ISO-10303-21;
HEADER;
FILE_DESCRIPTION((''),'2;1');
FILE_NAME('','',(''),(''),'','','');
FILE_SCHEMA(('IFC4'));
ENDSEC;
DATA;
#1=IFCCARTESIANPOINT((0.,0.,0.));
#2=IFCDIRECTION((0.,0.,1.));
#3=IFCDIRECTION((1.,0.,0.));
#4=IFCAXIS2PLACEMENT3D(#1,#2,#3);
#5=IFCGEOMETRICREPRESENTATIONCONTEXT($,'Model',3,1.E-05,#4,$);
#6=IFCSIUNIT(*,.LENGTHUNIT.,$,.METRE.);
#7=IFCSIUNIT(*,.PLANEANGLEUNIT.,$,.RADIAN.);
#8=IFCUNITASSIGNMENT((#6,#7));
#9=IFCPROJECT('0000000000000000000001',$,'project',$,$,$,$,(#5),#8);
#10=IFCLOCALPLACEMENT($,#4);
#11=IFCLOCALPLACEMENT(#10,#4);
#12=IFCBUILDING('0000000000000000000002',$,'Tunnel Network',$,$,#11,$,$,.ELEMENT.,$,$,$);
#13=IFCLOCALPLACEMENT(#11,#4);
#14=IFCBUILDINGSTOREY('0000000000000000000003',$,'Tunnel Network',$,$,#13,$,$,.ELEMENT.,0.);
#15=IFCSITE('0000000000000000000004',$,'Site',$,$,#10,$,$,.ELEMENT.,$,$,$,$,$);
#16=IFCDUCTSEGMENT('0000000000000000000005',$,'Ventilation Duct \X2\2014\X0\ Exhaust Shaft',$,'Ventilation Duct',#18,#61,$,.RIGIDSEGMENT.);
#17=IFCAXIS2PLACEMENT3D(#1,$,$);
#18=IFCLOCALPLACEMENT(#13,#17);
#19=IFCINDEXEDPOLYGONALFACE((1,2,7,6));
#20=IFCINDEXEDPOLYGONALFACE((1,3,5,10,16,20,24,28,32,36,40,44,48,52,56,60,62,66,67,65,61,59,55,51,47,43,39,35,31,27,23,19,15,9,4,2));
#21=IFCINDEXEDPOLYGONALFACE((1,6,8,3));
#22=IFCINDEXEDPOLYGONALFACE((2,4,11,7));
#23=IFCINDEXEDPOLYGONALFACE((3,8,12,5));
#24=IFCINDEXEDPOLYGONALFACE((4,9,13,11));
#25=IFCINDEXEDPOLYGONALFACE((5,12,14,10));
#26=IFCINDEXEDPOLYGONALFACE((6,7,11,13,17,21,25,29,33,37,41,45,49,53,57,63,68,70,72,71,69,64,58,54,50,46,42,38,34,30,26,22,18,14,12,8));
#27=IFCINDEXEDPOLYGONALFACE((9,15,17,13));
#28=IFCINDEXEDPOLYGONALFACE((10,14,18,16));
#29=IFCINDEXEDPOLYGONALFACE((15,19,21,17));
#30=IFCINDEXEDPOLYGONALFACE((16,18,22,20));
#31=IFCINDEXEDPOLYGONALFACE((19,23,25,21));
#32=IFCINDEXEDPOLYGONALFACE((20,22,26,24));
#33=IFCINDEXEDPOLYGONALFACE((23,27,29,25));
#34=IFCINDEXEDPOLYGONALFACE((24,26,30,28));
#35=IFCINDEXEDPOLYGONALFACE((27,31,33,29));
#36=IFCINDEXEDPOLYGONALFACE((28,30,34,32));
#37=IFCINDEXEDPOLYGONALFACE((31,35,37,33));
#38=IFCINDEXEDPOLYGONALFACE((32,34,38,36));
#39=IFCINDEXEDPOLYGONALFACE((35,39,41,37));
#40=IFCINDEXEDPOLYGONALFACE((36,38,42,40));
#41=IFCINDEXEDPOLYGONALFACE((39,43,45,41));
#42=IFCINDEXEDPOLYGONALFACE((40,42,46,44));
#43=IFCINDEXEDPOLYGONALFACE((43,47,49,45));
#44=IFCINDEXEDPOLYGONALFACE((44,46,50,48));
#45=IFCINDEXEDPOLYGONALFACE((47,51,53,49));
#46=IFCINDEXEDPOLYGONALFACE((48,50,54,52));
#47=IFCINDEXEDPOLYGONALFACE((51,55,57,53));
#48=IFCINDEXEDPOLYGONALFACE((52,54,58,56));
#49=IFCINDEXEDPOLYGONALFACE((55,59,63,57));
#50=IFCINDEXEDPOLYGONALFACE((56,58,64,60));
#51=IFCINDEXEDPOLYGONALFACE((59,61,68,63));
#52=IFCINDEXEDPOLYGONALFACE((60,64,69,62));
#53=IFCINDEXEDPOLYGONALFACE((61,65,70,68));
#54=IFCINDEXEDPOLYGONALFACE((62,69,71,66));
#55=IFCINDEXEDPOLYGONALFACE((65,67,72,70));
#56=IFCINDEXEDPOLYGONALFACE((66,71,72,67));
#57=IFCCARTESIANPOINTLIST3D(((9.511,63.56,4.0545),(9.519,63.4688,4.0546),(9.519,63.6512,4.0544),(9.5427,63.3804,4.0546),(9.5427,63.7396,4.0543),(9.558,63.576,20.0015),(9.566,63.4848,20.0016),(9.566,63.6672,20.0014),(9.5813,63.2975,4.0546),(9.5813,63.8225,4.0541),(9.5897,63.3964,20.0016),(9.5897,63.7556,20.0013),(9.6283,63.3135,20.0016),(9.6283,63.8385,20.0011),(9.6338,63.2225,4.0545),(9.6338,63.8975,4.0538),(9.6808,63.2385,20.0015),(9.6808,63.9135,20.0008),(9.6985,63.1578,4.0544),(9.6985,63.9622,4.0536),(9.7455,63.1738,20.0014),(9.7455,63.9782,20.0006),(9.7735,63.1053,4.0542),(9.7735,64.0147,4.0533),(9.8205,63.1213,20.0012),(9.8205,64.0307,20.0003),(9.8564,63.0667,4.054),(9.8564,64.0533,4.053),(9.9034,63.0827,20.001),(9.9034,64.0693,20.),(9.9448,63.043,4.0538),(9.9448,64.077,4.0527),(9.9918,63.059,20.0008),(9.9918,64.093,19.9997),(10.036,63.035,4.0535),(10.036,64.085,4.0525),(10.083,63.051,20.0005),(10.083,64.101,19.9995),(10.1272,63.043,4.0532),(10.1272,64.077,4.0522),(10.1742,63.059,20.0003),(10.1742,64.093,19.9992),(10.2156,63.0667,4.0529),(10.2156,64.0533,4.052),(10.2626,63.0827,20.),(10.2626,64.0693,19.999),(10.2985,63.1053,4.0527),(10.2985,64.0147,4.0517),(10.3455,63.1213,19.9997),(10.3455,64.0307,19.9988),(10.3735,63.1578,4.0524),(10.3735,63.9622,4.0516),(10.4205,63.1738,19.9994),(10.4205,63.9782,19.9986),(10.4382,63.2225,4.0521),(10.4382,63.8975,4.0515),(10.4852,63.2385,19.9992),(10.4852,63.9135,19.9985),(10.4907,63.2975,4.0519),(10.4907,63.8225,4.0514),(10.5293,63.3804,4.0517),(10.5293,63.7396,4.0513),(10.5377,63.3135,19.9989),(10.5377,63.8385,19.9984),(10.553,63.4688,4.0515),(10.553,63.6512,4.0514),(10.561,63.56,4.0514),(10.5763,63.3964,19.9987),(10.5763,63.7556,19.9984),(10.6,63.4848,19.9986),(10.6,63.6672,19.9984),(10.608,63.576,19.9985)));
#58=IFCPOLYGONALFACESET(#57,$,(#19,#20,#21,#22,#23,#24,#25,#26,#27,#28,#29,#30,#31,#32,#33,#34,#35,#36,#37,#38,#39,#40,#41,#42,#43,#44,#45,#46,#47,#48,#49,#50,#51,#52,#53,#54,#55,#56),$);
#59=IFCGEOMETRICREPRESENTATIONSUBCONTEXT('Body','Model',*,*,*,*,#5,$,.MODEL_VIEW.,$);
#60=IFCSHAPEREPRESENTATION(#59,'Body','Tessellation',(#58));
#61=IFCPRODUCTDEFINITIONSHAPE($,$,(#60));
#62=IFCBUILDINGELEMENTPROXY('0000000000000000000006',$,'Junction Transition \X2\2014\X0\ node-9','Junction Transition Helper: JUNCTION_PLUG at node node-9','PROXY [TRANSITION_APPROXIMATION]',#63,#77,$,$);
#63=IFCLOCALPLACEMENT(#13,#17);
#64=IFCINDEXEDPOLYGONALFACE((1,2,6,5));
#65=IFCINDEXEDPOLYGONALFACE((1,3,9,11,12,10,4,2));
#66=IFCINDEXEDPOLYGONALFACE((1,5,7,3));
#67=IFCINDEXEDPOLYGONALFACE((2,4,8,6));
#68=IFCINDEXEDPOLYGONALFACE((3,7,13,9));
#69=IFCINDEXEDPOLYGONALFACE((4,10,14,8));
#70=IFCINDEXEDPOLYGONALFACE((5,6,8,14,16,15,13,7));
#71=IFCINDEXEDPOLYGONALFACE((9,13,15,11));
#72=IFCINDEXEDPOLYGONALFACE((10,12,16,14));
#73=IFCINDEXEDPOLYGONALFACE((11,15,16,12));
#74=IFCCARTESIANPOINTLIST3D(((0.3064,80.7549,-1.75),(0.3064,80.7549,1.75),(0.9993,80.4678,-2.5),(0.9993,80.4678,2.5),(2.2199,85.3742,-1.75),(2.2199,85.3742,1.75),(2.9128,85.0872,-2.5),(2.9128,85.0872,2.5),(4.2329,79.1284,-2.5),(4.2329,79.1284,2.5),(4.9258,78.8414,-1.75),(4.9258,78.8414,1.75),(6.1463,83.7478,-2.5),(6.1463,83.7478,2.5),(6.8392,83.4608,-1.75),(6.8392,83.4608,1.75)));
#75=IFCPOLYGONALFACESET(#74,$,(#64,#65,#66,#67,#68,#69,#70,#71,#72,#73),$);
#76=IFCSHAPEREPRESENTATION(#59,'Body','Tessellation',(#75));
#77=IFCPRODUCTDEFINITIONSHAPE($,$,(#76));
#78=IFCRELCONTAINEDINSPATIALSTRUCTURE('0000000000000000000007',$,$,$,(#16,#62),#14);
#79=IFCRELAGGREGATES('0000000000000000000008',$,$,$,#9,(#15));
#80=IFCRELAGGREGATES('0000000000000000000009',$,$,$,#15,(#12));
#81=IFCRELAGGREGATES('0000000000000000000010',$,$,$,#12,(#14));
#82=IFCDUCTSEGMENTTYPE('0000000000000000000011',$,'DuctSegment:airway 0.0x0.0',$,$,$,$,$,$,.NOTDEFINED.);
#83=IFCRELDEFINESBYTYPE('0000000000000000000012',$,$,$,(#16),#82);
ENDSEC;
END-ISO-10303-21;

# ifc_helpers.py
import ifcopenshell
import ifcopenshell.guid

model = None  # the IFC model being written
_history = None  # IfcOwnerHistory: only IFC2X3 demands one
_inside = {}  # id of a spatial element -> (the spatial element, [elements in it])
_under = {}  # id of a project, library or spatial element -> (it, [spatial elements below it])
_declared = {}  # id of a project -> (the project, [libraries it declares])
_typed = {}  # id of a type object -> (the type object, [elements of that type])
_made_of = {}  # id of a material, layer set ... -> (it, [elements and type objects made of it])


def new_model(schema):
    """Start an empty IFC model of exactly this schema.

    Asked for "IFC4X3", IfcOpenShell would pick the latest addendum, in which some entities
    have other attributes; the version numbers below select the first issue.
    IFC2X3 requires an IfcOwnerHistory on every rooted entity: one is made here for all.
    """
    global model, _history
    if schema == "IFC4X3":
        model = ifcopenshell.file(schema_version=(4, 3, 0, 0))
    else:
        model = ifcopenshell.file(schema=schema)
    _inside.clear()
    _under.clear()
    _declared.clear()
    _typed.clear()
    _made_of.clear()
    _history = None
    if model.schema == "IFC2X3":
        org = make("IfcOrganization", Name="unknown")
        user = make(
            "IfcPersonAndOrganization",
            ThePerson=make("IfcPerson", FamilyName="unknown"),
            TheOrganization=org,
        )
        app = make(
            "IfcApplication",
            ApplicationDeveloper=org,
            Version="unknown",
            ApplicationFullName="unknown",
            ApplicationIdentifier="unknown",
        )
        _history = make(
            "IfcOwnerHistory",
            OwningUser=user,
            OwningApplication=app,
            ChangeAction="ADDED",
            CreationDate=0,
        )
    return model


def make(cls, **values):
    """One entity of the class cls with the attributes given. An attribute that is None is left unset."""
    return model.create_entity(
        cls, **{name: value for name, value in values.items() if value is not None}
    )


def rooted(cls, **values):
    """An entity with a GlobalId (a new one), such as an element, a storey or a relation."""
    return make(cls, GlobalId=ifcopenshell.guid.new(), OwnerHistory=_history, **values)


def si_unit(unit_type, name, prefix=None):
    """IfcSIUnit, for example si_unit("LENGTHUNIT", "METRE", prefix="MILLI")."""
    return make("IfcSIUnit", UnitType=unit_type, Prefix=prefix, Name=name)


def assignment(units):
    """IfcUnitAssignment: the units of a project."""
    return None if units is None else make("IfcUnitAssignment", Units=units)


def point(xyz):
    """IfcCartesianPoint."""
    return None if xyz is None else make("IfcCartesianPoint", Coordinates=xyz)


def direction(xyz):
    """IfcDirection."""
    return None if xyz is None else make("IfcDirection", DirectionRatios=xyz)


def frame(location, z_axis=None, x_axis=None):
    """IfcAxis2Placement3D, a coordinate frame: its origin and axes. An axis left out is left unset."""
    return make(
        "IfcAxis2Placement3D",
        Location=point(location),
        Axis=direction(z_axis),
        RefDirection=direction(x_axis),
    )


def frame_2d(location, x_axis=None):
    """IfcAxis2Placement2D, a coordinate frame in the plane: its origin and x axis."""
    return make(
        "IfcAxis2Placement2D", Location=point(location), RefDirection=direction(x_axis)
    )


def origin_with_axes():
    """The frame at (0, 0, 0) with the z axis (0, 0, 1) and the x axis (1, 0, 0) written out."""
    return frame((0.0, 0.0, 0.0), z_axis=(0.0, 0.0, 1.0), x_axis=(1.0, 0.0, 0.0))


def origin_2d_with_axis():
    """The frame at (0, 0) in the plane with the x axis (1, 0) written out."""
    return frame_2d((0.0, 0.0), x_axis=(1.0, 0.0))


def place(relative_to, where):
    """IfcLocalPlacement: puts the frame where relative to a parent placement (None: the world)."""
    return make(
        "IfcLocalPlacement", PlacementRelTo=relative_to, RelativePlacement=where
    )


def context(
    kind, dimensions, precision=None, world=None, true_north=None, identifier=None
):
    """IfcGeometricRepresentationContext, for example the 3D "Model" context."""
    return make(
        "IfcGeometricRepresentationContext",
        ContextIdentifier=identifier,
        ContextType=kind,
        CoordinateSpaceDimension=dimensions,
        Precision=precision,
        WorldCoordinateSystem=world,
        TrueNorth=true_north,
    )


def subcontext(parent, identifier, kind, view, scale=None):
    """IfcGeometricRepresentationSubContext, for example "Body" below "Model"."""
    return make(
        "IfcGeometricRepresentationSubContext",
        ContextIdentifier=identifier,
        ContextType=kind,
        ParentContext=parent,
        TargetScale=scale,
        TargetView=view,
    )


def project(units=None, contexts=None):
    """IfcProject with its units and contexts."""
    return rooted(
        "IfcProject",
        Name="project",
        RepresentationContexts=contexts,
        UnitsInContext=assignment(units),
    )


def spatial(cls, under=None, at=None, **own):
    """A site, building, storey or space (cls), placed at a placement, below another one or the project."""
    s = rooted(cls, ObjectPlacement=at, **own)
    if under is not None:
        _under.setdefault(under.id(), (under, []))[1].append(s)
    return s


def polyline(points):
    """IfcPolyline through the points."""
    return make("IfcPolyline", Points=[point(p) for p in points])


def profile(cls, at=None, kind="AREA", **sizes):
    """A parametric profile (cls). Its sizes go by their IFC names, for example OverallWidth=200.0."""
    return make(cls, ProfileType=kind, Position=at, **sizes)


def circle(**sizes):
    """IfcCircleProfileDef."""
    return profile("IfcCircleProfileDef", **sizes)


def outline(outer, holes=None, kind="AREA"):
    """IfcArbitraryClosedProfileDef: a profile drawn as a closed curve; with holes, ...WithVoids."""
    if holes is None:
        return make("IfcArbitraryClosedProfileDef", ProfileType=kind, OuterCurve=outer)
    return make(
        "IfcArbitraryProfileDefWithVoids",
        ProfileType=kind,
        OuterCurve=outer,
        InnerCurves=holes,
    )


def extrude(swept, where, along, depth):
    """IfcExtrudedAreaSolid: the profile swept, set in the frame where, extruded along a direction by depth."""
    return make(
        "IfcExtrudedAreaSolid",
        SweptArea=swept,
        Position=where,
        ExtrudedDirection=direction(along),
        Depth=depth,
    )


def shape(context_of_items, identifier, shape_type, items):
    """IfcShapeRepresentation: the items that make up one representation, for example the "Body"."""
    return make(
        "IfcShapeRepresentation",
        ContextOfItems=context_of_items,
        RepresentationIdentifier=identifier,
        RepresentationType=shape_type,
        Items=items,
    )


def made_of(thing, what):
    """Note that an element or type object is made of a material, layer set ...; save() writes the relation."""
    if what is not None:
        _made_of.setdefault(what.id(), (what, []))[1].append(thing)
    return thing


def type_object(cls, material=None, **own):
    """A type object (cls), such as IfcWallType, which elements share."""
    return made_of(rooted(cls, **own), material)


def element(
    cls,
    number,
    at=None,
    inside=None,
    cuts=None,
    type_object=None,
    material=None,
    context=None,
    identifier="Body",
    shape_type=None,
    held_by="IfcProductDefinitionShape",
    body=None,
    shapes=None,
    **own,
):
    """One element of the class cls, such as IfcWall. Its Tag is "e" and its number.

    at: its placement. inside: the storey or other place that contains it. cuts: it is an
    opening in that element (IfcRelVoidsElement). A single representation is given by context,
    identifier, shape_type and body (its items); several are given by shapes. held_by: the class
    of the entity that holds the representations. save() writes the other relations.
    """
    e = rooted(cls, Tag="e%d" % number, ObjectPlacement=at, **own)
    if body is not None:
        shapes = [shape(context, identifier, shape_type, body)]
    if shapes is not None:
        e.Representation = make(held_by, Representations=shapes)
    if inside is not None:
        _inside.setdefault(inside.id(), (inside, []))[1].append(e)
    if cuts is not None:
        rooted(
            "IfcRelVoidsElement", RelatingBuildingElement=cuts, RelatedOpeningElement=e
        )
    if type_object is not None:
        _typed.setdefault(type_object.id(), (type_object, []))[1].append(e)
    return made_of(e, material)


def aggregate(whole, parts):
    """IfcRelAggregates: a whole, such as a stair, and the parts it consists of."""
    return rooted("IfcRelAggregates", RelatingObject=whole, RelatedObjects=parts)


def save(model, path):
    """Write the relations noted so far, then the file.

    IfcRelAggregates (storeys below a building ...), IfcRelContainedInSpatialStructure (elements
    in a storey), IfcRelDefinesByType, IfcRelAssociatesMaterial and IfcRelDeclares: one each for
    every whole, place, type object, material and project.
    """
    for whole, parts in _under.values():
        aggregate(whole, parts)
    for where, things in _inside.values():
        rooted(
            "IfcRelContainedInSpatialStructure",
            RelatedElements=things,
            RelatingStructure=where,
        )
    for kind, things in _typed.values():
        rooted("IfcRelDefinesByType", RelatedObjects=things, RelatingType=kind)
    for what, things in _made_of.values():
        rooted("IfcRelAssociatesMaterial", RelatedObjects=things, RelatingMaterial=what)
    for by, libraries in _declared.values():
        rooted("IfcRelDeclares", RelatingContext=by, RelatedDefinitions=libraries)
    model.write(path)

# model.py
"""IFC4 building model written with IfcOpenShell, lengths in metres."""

from ifc_helpers import new_model, si_unit, frame, origin_with_axes, origin_2d_with_axis, place, context, subcontext, project, spatial, polyline, circle, outline, extrude, type_object, element, save


model = new_model("IFC4")

# Units and contexts
model_context = context("Model", 3, precision=1e-05, world=origin_with_axes())
body_context = subcontext(model_context, "Body", "Model", "MODEL_VIEW")
ifc_project = project(units=[si_unit("LENGTHUNIT", "METRE"), si_unit("PLANEANGLEUNIT", "RADIAN")], contexts=[model_context])

# Site, building, storey
site_placement = place(None, origin_with_axes())
site = spatial("IfcSite", under=ifc_project, at=site_placement, Name="Site", CompositionType="ELEMENT")
building_placement = place(site_placement, origin_with_axes())
building = spatial("IfcBuilding", under=site, at=building_placement, Name="Tunnel Network", CompositionType="ELEMENT")
storey_placement = place(building_placement, origin_with_axes())
storey = spatial("IfcBuildingStorey", under=building, at=storey_placement, Name="Tunnel Network", CompositionType="ELEMENT", Elevation=0.0)

# Duct segment
duct_segment_type = type_object("IfcDuctSegmentType", Name="DuctSegment:airway 0.0x0.0")
duct_segment_1_placement = place(storey_placement, frame((10.036, 63.56, 4.053), z_axis=(0.002947, 0.001003, 0.999995), x_axis=(0.999996, -0.000003, -0.002947)))
element("IfcDuctSegment", 1, at=duct_segment_1_placement, inside=storey, type_object=duct_segment_type, Name="Ventilation Duct — Exhaust Shaft", ObjectType="Ventilation Duct", PredefinedType="RIGIDSEGMENT", context=body_context, shape_type="SweptSolid", body=[
    extrude(circle(Radius=0.525, at=origin_2d_with_axis()), origin_with_axes(), (0.0, 0.0, 1.0), 15.9471),
])

# Building element proxy
proxy_placement = place(storey_placement, frame((4.5295, 84.4175, 0.0), z_axis=(-0.382684, -0.923879, 0.0), x_axis=(-0.923879, 0.382684, 0.0)))
element("IfcBuildingElementProxy", 2, at=proxy_placement, inside=storey, Name="Junction Transition — node-9", Description="Junction Transition Helper: JUNCTION_PLUG at node node-9", ObjectType="PROXY [TRANSITION_APPROXIMATION]", context=body_context, shape_type="SweptSolid", body=[
    extrude(outline(polyline([(1.75, 2.5), (2.5, 1.75), (2.5, -1.75), (1.75, -2.5), (-1.75, -2.5), (-2.5, -1.75), (-2.5, 1.75), (-1.75, 2.5), (1.75, 2.5)])), origin_with_axes(), (0.0, 0.0, 1.0), 5.0),
])

save(model, "model.ifc")
